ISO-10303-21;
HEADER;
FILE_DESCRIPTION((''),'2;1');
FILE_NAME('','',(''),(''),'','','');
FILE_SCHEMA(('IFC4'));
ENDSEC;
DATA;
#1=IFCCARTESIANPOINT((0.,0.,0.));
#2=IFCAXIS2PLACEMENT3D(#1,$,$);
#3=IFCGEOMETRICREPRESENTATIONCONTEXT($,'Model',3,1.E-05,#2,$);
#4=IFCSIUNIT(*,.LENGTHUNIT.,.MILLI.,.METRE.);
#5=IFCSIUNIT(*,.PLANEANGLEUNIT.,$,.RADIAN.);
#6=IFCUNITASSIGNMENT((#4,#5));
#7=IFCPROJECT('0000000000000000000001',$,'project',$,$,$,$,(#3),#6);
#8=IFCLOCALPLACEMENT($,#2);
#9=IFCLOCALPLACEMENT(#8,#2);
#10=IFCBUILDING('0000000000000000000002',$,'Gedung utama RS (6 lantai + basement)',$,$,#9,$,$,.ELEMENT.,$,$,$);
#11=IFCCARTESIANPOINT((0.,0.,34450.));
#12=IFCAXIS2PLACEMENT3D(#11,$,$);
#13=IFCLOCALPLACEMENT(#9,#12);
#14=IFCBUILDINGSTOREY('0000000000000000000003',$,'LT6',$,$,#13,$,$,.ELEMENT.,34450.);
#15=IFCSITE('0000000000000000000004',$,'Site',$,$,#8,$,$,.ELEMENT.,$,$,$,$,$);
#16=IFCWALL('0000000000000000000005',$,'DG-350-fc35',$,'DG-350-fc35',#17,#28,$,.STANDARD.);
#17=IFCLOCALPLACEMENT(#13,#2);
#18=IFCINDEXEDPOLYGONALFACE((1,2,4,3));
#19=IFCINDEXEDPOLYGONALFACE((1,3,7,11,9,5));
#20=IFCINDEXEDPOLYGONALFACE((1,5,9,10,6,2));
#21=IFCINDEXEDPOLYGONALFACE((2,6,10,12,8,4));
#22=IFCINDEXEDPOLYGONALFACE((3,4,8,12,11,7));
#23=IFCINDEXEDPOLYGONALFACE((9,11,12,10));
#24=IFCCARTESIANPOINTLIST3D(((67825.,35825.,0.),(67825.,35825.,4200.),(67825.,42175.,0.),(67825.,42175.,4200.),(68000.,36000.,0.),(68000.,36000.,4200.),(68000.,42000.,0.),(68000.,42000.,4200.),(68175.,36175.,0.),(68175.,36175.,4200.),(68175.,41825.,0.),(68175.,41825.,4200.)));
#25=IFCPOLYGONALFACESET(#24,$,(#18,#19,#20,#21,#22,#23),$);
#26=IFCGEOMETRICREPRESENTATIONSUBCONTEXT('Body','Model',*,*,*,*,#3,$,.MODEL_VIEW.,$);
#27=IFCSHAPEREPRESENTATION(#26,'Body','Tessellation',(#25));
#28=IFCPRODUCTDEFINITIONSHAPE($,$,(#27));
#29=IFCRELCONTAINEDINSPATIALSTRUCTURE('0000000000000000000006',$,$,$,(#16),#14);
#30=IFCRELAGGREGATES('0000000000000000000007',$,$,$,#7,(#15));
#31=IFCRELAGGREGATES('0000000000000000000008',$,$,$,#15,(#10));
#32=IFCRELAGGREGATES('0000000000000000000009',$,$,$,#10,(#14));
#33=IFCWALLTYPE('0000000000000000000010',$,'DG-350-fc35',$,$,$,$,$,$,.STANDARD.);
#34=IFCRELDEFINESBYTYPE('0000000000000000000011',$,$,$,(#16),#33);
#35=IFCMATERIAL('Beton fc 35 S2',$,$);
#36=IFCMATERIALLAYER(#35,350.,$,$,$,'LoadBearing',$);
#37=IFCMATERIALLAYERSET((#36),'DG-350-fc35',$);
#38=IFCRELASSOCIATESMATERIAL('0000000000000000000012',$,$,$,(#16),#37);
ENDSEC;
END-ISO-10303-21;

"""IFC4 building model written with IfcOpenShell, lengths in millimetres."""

from ifc_helpers import new_model, si_unit, frame, origin, place, context, subcontext, project, spatial, polyline, outline, extrude, material, layer, layer_set, layer_usage, type_object, element, save


model = new_model("IFC4")

# Units and contexts
model_context = context("Model", 3, precision=1e-05, world=origin())
body_context = subcontext(model_context, "Body", "Model", "MODEL_VIEW")
ifc_project = project(units=[si_unit("LENGTHUNIT", "METRE", prefix="MILLI"), si_unit("PLANEANGLEUNIT", "RADIAN")], contexts=[model_context])

# Site, building, storey
site_placement = place(None, origin())
site = spatial("IfcSite", under=ifc_project, at=site_placement, Name="Site", CompositionType="ELEMENT")
building_placement = place(site_placement, origin())
building = spatial("IfcBuilding", under=site, at=building_placement, Name="Gedung utama RS (6 lantai + basement)", CompositionType="ELEMENT")
storey_placement = place(building_placement, frame((0.0, 0.0, 34450.0)))
storey = spatial("IfcBuildingStorey", under=building, at=storey_placement, Name="LT6", CompositionType="ELEMENT", Elevation=34450.0)

# Shared definitions
ifc_material_1 = material(Name="Beton fc 35 S2")
ifc_layer = layer(ifc_material_1, 350.0, Category="LoadBearing")
ifc_layer_set = layer_set([ifc_layer], Name="DG-350-fc35")
ifc_layer_usage = layer_usage(ifc_layer_set, "AXIS2", "NEGATIVE", 175.0)
wall_type = type_object("IfcWallType", Name="DG-350-fc35", PredefinedType="STANDARD")

# Wall
wall_1_placement = place(storey_placement, frame((68000.0, 42000.0, 0.0), z_axis=(0.0, 0.0, 1.0), x_axis=(0.0, -1.0, 0.0)))
element("IfcWall", 1, at=wall_1_placement, inside=storey, type_object=wall_type, material=ifc_layer_usage, Name="DG-350-fc35", ObjectType="DG-350-fc35", PredefinedType="STANDARD", context=body_context, shape_type="SweptSolid", body=[
    extrude(outline(polyline([(-175.0, -175.0), (0.0, 0.0), (175.0, 175.0), (5825.0, 175.0), (6000.0, 0.0), (6175.0, -175.0), (-175.0, -175.0)])), origin(), (0.0, 0.0, 1.0), 4200.0),
])

save(model, "model.ifc")
